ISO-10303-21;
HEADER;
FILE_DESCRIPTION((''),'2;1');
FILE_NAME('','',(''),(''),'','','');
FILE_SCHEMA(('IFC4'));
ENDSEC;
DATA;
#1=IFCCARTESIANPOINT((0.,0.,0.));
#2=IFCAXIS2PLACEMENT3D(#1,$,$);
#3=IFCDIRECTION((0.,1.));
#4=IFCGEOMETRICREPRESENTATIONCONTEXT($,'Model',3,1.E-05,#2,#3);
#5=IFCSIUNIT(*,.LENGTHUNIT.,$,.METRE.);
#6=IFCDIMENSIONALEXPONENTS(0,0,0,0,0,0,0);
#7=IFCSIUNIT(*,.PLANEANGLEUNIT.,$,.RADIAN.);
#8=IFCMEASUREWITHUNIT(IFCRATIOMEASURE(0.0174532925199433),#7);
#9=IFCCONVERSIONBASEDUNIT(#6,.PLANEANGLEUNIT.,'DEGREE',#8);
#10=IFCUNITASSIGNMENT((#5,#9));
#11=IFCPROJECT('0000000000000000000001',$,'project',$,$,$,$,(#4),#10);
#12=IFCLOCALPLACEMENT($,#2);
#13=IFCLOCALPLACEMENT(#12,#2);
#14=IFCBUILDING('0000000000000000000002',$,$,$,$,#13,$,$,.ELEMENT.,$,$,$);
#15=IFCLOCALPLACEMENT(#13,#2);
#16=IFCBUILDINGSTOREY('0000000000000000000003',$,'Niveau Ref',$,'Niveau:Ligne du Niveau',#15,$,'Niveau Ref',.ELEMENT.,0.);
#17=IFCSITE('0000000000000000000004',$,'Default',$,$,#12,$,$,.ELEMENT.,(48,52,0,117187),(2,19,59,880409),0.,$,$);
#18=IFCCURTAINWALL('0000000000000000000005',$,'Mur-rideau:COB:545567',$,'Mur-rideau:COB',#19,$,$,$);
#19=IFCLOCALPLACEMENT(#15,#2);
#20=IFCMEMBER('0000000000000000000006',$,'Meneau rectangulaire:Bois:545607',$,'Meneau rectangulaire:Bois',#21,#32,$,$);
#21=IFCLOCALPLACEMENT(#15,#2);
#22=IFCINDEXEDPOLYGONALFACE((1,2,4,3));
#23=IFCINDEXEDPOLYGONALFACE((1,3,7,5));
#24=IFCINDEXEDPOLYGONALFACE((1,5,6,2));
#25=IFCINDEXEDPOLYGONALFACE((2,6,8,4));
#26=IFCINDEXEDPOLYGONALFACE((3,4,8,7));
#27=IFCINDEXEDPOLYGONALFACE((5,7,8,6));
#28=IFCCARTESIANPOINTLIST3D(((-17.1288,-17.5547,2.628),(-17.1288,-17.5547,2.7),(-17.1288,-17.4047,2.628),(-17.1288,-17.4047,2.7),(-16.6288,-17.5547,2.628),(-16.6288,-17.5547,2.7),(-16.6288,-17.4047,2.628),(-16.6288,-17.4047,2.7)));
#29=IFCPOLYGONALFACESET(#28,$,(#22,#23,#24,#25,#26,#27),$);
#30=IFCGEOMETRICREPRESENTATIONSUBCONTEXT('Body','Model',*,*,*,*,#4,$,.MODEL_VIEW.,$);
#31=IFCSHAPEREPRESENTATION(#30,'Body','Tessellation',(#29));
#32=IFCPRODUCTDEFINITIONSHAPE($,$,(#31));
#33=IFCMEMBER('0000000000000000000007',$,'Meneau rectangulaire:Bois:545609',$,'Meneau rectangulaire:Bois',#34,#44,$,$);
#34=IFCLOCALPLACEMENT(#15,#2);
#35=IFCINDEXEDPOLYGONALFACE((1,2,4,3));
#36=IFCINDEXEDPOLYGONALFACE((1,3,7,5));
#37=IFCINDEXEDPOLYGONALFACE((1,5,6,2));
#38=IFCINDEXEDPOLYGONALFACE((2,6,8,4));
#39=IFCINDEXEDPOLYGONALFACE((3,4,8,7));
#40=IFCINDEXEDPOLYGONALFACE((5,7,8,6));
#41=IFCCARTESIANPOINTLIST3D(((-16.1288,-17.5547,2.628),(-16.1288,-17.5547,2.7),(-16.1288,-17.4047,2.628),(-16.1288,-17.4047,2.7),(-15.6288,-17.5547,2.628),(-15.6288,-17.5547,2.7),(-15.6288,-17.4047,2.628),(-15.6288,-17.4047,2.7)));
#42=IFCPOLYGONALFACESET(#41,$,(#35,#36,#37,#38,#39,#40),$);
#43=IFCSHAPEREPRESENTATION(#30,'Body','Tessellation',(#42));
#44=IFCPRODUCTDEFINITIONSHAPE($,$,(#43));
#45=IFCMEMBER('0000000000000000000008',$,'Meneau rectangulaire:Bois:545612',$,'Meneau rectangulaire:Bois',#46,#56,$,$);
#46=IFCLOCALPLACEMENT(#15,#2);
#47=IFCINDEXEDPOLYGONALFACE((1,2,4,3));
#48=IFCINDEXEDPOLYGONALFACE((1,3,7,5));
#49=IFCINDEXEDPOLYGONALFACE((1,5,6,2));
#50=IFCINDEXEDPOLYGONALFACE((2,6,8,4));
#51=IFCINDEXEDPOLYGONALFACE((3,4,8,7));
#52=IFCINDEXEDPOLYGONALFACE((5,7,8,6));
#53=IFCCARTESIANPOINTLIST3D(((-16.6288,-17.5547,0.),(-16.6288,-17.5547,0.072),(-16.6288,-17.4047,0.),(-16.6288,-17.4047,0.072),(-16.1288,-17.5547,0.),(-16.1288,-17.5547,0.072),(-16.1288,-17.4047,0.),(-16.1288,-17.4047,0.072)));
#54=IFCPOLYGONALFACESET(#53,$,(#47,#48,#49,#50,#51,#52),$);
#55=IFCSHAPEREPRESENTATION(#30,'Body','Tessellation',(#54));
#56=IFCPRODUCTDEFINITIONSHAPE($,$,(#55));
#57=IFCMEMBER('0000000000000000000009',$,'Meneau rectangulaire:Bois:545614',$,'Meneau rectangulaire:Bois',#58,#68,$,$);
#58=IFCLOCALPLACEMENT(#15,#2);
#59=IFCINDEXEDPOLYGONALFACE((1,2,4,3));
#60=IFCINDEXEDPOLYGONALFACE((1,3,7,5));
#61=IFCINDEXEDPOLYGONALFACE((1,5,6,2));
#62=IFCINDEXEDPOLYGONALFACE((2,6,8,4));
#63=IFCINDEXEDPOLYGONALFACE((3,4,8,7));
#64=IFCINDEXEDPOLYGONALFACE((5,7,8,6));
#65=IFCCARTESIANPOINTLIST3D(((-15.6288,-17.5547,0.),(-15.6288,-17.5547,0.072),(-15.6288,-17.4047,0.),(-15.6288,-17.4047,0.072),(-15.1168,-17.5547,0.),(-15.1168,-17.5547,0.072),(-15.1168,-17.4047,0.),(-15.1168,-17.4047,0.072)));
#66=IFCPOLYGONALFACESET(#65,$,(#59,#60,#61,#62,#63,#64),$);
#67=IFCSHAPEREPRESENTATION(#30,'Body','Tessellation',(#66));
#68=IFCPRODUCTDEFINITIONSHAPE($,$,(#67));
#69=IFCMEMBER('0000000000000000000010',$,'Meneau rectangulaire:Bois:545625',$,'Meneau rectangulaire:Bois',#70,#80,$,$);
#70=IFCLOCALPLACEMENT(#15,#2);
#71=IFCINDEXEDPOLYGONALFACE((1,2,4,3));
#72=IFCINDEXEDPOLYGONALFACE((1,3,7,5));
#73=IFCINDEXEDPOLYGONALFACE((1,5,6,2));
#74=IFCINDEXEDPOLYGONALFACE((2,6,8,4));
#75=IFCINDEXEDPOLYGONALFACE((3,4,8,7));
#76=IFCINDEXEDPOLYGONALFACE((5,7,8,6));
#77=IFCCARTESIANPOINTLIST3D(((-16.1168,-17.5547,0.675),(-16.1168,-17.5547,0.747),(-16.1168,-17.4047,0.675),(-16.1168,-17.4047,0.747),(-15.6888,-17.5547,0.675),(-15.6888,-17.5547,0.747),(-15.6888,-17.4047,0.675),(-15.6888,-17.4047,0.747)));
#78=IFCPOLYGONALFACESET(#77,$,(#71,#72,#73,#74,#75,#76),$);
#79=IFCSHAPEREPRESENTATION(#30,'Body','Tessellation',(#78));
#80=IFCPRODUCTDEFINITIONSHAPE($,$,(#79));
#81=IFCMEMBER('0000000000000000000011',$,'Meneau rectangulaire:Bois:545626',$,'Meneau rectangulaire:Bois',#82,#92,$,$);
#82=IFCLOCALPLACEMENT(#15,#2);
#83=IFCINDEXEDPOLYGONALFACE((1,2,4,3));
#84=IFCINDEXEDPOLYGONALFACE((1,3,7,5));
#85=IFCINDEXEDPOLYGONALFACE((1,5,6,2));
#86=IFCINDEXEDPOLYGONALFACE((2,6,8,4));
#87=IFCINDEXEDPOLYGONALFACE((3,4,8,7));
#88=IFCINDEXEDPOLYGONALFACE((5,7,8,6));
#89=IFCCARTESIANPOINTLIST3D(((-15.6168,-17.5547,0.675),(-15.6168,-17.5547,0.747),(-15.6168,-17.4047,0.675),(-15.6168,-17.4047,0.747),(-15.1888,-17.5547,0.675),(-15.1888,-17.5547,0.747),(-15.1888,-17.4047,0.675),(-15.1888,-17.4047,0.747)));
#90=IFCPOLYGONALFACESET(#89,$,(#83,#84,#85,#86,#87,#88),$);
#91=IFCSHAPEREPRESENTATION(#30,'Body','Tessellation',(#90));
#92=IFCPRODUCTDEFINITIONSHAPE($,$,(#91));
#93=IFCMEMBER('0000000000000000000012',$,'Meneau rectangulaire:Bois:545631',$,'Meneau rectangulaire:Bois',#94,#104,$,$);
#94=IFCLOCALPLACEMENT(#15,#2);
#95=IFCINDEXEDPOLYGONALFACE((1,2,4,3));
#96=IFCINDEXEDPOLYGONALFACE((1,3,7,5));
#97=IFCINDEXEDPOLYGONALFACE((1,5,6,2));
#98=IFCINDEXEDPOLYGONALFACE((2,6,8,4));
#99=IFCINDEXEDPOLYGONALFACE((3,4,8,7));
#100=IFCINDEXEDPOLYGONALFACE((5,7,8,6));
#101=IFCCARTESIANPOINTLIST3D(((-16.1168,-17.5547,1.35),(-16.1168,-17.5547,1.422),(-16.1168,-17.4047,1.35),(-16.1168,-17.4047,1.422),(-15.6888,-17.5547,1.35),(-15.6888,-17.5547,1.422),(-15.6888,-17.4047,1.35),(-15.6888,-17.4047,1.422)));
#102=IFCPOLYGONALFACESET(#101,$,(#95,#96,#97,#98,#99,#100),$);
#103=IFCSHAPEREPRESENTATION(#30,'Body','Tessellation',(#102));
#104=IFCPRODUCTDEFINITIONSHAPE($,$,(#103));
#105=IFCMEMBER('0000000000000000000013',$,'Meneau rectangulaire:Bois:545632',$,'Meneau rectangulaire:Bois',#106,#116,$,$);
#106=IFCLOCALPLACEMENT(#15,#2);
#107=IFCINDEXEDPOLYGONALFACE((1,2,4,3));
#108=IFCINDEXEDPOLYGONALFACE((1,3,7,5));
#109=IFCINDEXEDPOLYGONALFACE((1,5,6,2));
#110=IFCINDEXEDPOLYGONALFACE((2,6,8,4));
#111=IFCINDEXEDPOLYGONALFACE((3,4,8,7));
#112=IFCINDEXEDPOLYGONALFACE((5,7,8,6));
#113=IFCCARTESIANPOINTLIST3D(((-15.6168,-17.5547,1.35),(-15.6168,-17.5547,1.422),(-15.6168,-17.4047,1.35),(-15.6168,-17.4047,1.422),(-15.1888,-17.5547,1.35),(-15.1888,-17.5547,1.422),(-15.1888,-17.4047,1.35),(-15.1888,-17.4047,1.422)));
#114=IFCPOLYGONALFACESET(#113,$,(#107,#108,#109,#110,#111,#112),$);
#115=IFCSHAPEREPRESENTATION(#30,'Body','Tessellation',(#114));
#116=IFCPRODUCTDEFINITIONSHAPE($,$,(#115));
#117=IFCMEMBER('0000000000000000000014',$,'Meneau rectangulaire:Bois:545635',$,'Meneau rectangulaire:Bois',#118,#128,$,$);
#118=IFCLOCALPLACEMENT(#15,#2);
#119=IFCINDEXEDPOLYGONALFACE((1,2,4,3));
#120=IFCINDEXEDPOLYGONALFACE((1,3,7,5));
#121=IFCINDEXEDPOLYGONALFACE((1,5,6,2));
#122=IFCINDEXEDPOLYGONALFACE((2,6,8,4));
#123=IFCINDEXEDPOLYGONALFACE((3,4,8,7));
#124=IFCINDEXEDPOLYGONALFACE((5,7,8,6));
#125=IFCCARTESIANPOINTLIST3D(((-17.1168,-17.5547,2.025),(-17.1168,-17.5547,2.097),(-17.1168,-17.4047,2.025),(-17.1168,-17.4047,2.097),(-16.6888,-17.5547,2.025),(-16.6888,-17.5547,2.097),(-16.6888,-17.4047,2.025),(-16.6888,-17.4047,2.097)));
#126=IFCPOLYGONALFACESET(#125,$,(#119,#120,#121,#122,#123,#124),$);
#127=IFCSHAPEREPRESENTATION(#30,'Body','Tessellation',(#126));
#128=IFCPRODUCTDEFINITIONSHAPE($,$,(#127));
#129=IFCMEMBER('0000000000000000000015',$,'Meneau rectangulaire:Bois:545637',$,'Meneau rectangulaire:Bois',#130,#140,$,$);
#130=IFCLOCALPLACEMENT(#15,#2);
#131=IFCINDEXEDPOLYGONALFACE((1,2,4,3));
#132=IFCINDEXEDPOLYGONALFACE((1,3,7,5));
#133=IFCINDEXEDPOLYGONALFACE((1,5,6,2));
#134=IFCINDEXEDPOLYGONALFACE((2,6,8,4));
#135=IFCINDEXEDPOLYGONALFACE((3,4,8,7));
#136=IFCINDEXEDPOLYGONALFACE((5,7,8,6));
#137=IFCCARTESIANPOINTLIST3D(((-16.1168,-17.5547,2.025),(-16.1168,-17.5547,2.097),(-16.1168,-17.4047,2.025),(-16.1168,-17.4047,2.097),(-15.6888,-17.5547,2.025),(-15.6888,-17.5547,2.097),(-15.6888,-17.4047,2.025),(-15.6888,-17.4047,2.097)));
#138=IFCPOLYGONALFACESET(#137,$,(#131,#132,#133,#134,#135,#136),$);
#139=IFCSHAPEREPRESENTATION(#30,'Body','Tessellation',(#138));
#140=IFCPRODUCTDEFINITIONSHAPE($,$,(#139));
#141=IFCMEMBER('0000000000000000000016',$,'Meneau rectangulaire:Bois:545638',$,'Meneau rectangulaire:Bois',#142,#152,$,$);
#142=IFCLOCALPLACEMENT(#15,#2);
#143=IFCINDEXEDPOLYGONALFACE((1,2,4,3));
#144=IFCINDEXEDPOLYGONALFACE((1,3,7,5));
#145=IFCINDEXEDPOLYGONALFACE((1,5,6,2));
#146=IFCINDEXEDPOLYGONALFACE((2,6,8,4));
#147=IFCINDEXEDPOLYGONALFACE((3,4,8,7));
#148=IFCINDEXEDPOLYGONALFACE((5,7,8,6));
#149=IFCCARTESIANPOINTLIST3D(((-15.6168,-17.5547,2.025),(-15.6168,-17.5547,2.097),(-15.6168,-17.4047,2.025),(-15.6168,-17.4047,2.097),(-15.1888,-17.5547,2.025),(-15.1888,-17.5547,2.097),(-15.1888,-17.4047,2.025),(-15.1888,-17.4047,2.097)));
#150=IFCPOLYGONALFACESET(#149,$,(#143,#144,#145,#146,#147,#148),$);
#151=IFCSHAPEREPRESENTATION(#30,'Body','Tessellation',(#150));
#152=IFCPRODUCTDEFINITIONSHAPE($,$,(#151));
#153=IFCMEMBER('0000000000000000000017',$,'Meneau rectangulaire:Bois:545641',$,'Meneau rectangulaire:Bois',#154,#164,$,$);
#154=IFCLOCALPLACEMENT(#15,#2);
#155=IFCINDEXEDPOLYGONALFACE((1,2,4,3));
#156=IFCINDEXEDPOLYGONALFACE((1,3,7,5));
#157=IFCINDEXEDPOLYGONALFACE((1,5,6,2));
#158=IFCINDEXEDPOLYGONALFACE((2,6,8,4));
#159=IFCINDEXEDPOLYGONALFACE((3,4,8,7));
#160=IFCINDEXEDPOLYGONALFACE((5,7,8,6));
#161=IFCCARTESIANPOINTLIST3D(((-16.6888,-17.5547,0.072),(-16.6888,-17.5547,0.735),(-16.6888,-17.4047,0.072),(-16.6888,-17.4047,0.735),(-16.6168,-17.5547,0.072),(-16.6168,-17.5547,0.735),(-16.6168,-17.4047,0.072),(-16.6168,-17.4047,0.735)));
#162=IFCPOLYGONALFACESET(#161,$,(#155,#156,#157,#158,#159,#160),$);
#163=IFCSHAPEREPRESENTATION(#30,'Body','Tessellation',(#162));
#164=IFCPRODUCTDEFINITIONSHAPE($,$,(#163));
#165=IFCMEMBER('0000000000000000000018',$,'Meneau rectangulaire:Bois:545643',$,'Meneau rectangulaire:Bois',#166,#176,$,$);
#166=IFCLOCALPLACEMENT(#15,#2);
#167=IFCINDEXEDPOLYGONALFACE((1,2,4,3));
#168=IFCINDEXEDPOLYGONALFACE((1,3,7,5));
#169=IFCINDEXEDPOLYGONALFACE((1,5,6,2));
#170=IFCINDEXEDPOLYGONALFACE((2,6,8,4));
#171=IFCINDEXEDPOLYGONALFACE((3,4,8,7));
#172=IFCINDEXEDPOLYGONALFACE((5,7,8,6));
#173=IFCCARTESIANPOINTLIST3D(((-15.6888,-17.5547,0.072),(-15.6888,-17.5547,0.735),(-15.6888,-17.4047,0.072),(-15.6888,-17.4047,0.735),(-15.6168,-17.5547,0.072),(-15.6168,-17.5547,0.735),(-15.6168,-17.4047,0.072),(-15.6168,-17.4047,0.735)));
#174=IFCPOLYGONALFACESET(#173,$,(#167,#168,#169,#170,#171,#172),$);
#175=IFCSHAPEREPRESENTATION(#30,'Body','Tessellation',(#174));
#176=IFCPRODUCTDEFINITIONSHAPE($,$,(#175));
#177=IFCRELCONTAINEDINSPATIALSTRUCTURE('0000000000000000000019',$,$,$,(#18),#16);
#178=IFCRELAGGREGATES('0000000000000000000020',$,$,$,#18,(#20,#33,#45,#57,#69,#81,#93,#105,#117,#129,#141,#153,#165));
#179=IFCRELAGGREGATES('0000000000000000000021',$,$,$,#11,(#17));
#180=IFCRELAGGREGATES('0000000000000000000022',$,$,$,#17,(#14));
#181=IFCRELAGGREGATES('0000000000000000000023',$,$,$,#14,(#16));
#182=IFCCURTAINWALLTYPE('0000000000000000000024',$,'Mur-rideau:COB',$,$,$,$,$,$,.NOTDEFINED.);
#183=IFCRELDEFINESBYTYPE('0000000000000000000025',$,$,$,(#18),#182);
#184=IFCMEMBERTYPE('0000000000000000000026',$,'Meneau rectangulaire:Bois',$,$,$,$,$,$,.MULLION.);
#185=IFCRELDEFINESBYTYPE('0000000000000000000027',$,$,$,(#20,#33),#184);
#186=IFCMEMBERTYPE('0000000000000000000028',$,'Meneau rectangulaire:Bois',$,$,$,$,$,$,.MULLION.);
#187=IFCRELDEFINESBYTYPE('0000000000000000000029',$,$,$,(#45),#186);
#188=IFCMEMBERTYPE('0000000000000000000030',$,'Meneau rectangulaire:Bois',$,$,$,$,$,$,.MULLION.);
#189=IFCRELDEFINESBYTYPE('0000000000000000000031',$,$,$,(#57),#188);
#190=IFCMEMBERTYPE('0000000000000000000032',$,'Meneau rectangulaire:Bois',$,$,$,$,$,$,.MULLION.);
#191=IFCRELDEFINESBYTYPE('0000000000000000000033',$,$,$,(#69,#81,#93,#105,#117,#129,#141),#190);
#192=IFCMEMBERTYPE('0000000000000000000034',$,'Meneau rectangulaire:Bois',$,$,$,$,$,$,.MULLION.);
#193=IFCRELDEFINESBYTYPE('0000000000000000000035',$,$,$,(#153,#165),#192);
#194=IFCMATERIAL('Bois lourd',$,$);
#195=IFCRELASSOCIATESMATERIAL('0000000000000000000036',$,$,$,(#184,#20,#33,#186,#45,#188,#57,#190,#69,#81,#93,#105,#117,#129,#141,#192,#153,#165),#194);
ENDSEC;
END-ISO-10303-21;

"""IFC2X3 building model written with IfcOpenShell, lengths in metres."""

from ifc_helpers import new_model, entity, si_unit, converted_unit, direction, frame, origin, origin_2d_with_axis, place, context, subcontext, project, spatial, rectangle, extrude, source, transform, mapped, material, type_object, type_shapes, element, aggregate, save


model = new_model("IFC2X3")

# Units and contexts
model_context = context("Model", 3, precision=1e-05, world=origin(), true_north=direction((0.0, 1.0)))
body_context = subcontext(model_context, "Body", "Model", "MODEL_VIEW")
ifc_project = project(units=[si_unit("LENGTHUNIT", "METRE"), converted_unit("PLANEANGLEUNIT", "DEGREE", entity("IfcRatioMeasure", 0.0174532925199433), si_unit("PLANEANGLEUNIT", "RADIAN"), dimensions=[0, 0, 0, 0, 0, 0, 0])], contexts=[model_context])

# Site, building, storey
site_placement = place(None, origin())
site = spatial("IfcSite", under=ifc_project, at=site_placement, Name="Default", CompositionType="ELEMENT", RefLatitude=(48, 52, 0, 117187), RefLongitude=(2, 19, 59, 880409), RefElevation=0.0)
building_placement = place(site_placement, origin())
building = spatial("IfcBuilding", under=site, at=building_placement, CompositionType="ELEMENT")
storey_placement = place(building_placement, origin())
storey = spatial("IfcBuildingStorey", under=building, at=storey_placement, Name="Niveau Ref", ObjectType="Niveau:Ligne du Niveau", LongName="Niveau Ref", CompositionType="ELEMENT", Elevation=0.0)

# Curtain wall, members
curtain_wall_type_1 = type_object("IfcCurtainWallType", Name="Mur-rideau:COB", PredefinedType="NOTDEFINED")
curtain_wall_1_placement = place(storey_placement, origin())
curtain_wall_1 = element("IfcCurtainWall", 1, at=curtain_wall_1_placement, inside=storey, type_object=curtain_wall_type_1, Name="Mur-rideau:COB:545567", ObjectType="Mur-rideau:COB")
ifc_material_1 = material(Name="Bois lourd")
member_type_1 = type_object("IfcMemberType", Name="Meneau rectangulaire:Bois", PredefinedType="MULLION", material=ifc_material_1)
shared_shape_1 = source(origin(), body_context, "Body", "SweptSolid", [
    extrude(rectangle(XDim=0.15, YDim=0.072, at=origin_2d_with_axis()), frame((-0.036, 0.0, -0.5), z_axis=(0.0, 0.0, 1.0), x_axis=(0.0, -1.0, 0.0)), (0.0, 0.0, 1.0), 0.5),
])
type_shapes(member_type_1, [shared_shape_1])
member_1_placement = place(storey_placement, frame((-16.6288, -17.4797, 2.7), z_axis=(1.0, 0.0, 0.0), x_axis=(0.0, 0.0, 1.0)))
member_1 = element("IfcMember", 2, at=member_1_placement, type_object=member_type_1, material=ifc_material_1, Name="Meneau rectangulaire:Bois:545607", ObjectType="Meneau rectangulaire:Bois", context=body_context, shape_type="MappedRepresentation", body=[
    mapped(shared_shape_1, transform((0.0, 0.0, 0.0), scale=1.0)),
])
member_2_placement = place(storey_placement, frame((-15.6288, -17.4797, 2.7), z_axis=(1.0, 0.0, 0.0), x_axis=(0.0, 0.0, 1.0)))
member_2 = element("IfcMember", 3, at=member_2_placement, type_object=member_type_1, material=ifc_material_1, Name="Meneau rectangulaire:Bois:545609", ObjectType="Meneau rectangulaire:Bois", context=body_context, shape_type="MappedRepresentation", body=[
    mapped(shared_shape_1, transform((0.0, 0.0, 0.0), scale=1.0)),
])
member_type_2 = type_object("IfcMemberType", Name="Meneau rectangulaire:Bois", PredefinedType="MULLION", material=ifc_material_1)
shared_shape_2 = source(origin(), body_context, "Body", "SweptSolid", [
    extrude(rectangle(XDim=0.15, YDim=0.072, at=origin_2d_with_axis()), frame((-0.036, 0.0, -0.5), z_axis=(0.0, 0.0, 1.0), x_axis=(0.0, -1.0, 0.0)), (0.0, 0.0, 1.0), 0.5),
])
type_shapes(member_type_2, [shared_shape_2])
member_3_placement = place(storey_placement, frame((-16.6288, -17.4797, 0.0), z_axis=(-1.0, 0.0, 0.0), x_axis=(0.0, 0.0, -1.0)))
member_3 = element("IfcMember", 4, at=member_3_placement, type_object=member_type_2, material=ifc_material_1, Name="Meneau rectangulaire:Bois:545612", ObjectType="Meneau rectangulaire:Bois", context=body_context, shape_type="MappedRepresentation", body=[
    mapped(shared_shape_2, transform((0.0, 0.0, 0.0), scale=1.0)),
])
member_type_3 = type_object("IfcMemberType", Name="Meneau rectangulaire:Bois", PredefinedType="MULLION", material=ifc_material_1)
shared_shape_3 = source(origin(), body_context, "Body", "SweptSolid", [
    extrude(rectangle(XDim=0.15, YDim=0.072, at=origin_2d_with_axis()), frame((-0.036, 0.0, -0.512), z_axis=(0.0, 0.0, 1.0), x_axis=(0.0, -1.0, 0.0)), (0.0, 0.0, 1.0), 0.512),
])
type_shapes(member_type_3, [shared_shape_3])
member_4_placement = place(storey_placement, frame((-15.6288, -17.4797, 0.0), z_axis=(-1.0, 0.0, 0.0), x_axis=(0.0, 0.0, -1.0)))
member_4 = element("IfcMember", 5, at=member_4_placement, type_object=member_type_3, material=ifc_material_1, Name="Meneau rectangulaire:Bois:545614", ObjectType="Meneau rectangulaire:Bois", context=body_context, shape_type="MappedRepresentation", body=[
    mapped(shared_shape_3, transform((0.0, 0.0, 0.0), scale=1.0)),
])
member_type_4 = type_object("IfcMemberType", Name="Meneau rectangulaire:Bois", PredefinedType="MULLION", material=ifc_material_1)
shared_shape_4 = source(origin(), body_context, "Body", "SweptSolid", [
    extrude(rectangle(XDim=0.15, YDim=0.072, at=origin_2d_with_axis()), frame((-0.024, 0.0, -0.428), z_axis=(0.0, 0.0, 1.0), x_axis=(0.0, -1.0, 0.0)), (0.0, 0.0, 1.0), 0.428),
])
type_shapes(member_type_4, [shared_shape_4])
member_5_placement = place(storey_placement, frame((-15.6888, -17.4797, 0.735), z_axis=(1.0, 0.0, 0.0), x_axis=(0.0, 0.0, 1.0)))
member_5 = element("IfcMember", 6, at=member_5_placement, type_object=member_type_4, material=ifc_material_1, Name="Meneau rectangulaire:Bois:545625", ObjectType="Meneau rectangulaire:Bois", context=body_context, shape_type="MappedRepresentation", body=[
    mapped(shared_shape_4, transform((0.0, 0.0, 0.0), scale=1.0)),
])
member_6_placement = place(storey_placement, frame((-15.1888, -17.4797, 0.735), z_axis=(1.0, 0.0, 0.0), x_axis=(0.0, 0.0, 1.0)))
member_6 = element("IfcMember", 7, at=member_6_placement, type_object=member_type_4, material=ifc_material_1, Name="Meneau rectangulaire:Bois:545626", ObjectType="Meneau rectangulaire:Bois", context=body_context, shape_type="MappedRepresentation", body=[
    mapped(shared_shape_4, transform((0.0, 0.0, 0.0), scale=1.0)),
])
member_7_placement = place(storey_placement, frame((-15.6888, -17.4797, 1.41), z_axis=(1.0, 0.0, 0.0), x_axis=(0.0, 0.0, 1.0)))
member_7 = element("IfcMember", 8, at=member_7_placement, type_object=member_type_4, material=ifc_material_1, Name="Meneau rectangulaire:Bois:545631", ObjectType="Meneau rectangulaire:Bois", context=body_context, shape_type="MappedRepresentation", body=[
    mapped(shared_shape_4, transform((0.0, 0.0, 0.0), scale=1.0)),
])
member_8_placement = place(storey_placement, frame((-15.1888, -17.4797, 1.41), z_axis=(1.0, 0.0, 0.0), x_axis=(0.0, 0.0, 1.0)))
member_8 = element("IfcMember", 9, at=member_8_placement, type_object=member_type_4, material=ifc_material_1, Name="Meneau rectangulaire:Bois:545632", ObjectType="Meneau rectangulaire:Bois", context=body_context, shape_type="MappedRepresentation", body=[
    mapped(shared_shape_4, transform((0.0, 0.0, 0.0), scale=1.0)),
])
member_9_placement = place(storey_placement, frame((-16.6888, -17.4797, 2.085), z_axis=(1.0, 0.0, 0.0), x_axis=(0.0, 0.0, 1.0)))
member_9 = element("IfcMember", 10, at=member_9_placement, type_object=member_type_4, material=ifc_material_1, Name="Meneau rectangulaire:Bois:545635", ObjectType="Meneau rectangulaire:Bois", context=body_context, shape_type="MappedRepresentation", body=[
    mapped(shared_shape_4, transform((0.0, 0.0, 0.0), scale=1.0)),
])
member_10_placement = place(storey_placement, frame((-15.6888, -17.4797, 2.085), z_axis=(1.0, 0.0, 0.0), x_axis=(0.0, 0.0, 1.0)))
member_10 = element("IfcMember", 11, at=member_10_placement, type_object=member_type_4, material=ifc_material_1, Name="Meneau rectangulaire:Bois:545637", ObjectType="Meneau rectangulaire:Bois", context=body_context, shape_type="MappedRepresentation", body=[
    mapped(shared_shape_4, transform((0.0, 0.0, 0.0), scale=1.0)),
])
member_11_placement = place(storey_placement, frame((-15.1888, -17.4797, 2.085), z_axis=(1.0, 0.0, 0.0), x_axis=(0.0, 0.0, 1.0)))
member_11 = element("IfcMember", 12, at=member_11_placement, type_object=member_type_4, material=ifc_material_1, Name="Meneau rectangulaire:Bois:545638", ObjectType="Meneau rectangulaire:Bois", context=body_context, shape_type="MappedRepresentation", body=[
    mapped(shared_shape_4, transform((0.0, 0.0, 0.0), scale=1.0)),
])
member_type_5 = type_object("IfcMemberType", Name="Meneau rectangulaire:Bois", PredefinedType="MULLION", material=ifc_material_1)
shared_shape_5 = source(origin(), body_context, "Body", "SweptSolid", [
    extrude(rectangle(XDim=0.15, YDim=0.072, at=origin_2d_with_axis()), frame((-0.024, 0.0, -0.663), z_axis=(0.0, 0.0, 1.0), x_axis=(0.0, -1.0, 0.0)), (0.0, 0.0, 1.0), 0.663),
])
type_shapes(member_type_5, [shared_shape_5])
member_12_placement = place(storey_placement, frame((-16.6288, -17.4797, 0.072), z_axis=(0.0, 0.0, -1.0), x_axis=(1.0, 0.0, 0.0)))
member_12 = element("IfcMember", 13, at=member_12_placement, type_object=member_type_5, material=ifc_material_1, Name="Meneau rectangulaire:Bois:545641", ObjectType="Meneau rectangulaire:Bois", context=body_context, shape_type="MappedRepresentation", body=[
    mapped(shared_shape_5, transform((0.0, 0.0, 0.0), scale=1.0)),
])
member_13_placement = place(storey_placement, frame((-15.6288, -17.4797, 0.072), z_axis=(0.0, 0.0, -1.0), x_axis=(1.0, 0.0, 0.0)))
member_13 = element("IfcMember", 14, at=member_13_placement, type_object=member_type_5, material=ifc_material_1, Name="Meneau rectangulaire:Bois:545643", ObjectType="Meneau rectangulaire:Bois", context=body_context, shape_type="MappedRepresentation", body=[
    mapped(shared_shape_5, transform((0.0, 0.0, 0.0), scale=1.0)),
])
aggregate(curtain_wall_1, [member_1, member_2, member_3, member_4, member_5, member_6, member_7, member_8, member_9, member_10, member_11, member_12, member_13])

save(model, "model.ifc")
